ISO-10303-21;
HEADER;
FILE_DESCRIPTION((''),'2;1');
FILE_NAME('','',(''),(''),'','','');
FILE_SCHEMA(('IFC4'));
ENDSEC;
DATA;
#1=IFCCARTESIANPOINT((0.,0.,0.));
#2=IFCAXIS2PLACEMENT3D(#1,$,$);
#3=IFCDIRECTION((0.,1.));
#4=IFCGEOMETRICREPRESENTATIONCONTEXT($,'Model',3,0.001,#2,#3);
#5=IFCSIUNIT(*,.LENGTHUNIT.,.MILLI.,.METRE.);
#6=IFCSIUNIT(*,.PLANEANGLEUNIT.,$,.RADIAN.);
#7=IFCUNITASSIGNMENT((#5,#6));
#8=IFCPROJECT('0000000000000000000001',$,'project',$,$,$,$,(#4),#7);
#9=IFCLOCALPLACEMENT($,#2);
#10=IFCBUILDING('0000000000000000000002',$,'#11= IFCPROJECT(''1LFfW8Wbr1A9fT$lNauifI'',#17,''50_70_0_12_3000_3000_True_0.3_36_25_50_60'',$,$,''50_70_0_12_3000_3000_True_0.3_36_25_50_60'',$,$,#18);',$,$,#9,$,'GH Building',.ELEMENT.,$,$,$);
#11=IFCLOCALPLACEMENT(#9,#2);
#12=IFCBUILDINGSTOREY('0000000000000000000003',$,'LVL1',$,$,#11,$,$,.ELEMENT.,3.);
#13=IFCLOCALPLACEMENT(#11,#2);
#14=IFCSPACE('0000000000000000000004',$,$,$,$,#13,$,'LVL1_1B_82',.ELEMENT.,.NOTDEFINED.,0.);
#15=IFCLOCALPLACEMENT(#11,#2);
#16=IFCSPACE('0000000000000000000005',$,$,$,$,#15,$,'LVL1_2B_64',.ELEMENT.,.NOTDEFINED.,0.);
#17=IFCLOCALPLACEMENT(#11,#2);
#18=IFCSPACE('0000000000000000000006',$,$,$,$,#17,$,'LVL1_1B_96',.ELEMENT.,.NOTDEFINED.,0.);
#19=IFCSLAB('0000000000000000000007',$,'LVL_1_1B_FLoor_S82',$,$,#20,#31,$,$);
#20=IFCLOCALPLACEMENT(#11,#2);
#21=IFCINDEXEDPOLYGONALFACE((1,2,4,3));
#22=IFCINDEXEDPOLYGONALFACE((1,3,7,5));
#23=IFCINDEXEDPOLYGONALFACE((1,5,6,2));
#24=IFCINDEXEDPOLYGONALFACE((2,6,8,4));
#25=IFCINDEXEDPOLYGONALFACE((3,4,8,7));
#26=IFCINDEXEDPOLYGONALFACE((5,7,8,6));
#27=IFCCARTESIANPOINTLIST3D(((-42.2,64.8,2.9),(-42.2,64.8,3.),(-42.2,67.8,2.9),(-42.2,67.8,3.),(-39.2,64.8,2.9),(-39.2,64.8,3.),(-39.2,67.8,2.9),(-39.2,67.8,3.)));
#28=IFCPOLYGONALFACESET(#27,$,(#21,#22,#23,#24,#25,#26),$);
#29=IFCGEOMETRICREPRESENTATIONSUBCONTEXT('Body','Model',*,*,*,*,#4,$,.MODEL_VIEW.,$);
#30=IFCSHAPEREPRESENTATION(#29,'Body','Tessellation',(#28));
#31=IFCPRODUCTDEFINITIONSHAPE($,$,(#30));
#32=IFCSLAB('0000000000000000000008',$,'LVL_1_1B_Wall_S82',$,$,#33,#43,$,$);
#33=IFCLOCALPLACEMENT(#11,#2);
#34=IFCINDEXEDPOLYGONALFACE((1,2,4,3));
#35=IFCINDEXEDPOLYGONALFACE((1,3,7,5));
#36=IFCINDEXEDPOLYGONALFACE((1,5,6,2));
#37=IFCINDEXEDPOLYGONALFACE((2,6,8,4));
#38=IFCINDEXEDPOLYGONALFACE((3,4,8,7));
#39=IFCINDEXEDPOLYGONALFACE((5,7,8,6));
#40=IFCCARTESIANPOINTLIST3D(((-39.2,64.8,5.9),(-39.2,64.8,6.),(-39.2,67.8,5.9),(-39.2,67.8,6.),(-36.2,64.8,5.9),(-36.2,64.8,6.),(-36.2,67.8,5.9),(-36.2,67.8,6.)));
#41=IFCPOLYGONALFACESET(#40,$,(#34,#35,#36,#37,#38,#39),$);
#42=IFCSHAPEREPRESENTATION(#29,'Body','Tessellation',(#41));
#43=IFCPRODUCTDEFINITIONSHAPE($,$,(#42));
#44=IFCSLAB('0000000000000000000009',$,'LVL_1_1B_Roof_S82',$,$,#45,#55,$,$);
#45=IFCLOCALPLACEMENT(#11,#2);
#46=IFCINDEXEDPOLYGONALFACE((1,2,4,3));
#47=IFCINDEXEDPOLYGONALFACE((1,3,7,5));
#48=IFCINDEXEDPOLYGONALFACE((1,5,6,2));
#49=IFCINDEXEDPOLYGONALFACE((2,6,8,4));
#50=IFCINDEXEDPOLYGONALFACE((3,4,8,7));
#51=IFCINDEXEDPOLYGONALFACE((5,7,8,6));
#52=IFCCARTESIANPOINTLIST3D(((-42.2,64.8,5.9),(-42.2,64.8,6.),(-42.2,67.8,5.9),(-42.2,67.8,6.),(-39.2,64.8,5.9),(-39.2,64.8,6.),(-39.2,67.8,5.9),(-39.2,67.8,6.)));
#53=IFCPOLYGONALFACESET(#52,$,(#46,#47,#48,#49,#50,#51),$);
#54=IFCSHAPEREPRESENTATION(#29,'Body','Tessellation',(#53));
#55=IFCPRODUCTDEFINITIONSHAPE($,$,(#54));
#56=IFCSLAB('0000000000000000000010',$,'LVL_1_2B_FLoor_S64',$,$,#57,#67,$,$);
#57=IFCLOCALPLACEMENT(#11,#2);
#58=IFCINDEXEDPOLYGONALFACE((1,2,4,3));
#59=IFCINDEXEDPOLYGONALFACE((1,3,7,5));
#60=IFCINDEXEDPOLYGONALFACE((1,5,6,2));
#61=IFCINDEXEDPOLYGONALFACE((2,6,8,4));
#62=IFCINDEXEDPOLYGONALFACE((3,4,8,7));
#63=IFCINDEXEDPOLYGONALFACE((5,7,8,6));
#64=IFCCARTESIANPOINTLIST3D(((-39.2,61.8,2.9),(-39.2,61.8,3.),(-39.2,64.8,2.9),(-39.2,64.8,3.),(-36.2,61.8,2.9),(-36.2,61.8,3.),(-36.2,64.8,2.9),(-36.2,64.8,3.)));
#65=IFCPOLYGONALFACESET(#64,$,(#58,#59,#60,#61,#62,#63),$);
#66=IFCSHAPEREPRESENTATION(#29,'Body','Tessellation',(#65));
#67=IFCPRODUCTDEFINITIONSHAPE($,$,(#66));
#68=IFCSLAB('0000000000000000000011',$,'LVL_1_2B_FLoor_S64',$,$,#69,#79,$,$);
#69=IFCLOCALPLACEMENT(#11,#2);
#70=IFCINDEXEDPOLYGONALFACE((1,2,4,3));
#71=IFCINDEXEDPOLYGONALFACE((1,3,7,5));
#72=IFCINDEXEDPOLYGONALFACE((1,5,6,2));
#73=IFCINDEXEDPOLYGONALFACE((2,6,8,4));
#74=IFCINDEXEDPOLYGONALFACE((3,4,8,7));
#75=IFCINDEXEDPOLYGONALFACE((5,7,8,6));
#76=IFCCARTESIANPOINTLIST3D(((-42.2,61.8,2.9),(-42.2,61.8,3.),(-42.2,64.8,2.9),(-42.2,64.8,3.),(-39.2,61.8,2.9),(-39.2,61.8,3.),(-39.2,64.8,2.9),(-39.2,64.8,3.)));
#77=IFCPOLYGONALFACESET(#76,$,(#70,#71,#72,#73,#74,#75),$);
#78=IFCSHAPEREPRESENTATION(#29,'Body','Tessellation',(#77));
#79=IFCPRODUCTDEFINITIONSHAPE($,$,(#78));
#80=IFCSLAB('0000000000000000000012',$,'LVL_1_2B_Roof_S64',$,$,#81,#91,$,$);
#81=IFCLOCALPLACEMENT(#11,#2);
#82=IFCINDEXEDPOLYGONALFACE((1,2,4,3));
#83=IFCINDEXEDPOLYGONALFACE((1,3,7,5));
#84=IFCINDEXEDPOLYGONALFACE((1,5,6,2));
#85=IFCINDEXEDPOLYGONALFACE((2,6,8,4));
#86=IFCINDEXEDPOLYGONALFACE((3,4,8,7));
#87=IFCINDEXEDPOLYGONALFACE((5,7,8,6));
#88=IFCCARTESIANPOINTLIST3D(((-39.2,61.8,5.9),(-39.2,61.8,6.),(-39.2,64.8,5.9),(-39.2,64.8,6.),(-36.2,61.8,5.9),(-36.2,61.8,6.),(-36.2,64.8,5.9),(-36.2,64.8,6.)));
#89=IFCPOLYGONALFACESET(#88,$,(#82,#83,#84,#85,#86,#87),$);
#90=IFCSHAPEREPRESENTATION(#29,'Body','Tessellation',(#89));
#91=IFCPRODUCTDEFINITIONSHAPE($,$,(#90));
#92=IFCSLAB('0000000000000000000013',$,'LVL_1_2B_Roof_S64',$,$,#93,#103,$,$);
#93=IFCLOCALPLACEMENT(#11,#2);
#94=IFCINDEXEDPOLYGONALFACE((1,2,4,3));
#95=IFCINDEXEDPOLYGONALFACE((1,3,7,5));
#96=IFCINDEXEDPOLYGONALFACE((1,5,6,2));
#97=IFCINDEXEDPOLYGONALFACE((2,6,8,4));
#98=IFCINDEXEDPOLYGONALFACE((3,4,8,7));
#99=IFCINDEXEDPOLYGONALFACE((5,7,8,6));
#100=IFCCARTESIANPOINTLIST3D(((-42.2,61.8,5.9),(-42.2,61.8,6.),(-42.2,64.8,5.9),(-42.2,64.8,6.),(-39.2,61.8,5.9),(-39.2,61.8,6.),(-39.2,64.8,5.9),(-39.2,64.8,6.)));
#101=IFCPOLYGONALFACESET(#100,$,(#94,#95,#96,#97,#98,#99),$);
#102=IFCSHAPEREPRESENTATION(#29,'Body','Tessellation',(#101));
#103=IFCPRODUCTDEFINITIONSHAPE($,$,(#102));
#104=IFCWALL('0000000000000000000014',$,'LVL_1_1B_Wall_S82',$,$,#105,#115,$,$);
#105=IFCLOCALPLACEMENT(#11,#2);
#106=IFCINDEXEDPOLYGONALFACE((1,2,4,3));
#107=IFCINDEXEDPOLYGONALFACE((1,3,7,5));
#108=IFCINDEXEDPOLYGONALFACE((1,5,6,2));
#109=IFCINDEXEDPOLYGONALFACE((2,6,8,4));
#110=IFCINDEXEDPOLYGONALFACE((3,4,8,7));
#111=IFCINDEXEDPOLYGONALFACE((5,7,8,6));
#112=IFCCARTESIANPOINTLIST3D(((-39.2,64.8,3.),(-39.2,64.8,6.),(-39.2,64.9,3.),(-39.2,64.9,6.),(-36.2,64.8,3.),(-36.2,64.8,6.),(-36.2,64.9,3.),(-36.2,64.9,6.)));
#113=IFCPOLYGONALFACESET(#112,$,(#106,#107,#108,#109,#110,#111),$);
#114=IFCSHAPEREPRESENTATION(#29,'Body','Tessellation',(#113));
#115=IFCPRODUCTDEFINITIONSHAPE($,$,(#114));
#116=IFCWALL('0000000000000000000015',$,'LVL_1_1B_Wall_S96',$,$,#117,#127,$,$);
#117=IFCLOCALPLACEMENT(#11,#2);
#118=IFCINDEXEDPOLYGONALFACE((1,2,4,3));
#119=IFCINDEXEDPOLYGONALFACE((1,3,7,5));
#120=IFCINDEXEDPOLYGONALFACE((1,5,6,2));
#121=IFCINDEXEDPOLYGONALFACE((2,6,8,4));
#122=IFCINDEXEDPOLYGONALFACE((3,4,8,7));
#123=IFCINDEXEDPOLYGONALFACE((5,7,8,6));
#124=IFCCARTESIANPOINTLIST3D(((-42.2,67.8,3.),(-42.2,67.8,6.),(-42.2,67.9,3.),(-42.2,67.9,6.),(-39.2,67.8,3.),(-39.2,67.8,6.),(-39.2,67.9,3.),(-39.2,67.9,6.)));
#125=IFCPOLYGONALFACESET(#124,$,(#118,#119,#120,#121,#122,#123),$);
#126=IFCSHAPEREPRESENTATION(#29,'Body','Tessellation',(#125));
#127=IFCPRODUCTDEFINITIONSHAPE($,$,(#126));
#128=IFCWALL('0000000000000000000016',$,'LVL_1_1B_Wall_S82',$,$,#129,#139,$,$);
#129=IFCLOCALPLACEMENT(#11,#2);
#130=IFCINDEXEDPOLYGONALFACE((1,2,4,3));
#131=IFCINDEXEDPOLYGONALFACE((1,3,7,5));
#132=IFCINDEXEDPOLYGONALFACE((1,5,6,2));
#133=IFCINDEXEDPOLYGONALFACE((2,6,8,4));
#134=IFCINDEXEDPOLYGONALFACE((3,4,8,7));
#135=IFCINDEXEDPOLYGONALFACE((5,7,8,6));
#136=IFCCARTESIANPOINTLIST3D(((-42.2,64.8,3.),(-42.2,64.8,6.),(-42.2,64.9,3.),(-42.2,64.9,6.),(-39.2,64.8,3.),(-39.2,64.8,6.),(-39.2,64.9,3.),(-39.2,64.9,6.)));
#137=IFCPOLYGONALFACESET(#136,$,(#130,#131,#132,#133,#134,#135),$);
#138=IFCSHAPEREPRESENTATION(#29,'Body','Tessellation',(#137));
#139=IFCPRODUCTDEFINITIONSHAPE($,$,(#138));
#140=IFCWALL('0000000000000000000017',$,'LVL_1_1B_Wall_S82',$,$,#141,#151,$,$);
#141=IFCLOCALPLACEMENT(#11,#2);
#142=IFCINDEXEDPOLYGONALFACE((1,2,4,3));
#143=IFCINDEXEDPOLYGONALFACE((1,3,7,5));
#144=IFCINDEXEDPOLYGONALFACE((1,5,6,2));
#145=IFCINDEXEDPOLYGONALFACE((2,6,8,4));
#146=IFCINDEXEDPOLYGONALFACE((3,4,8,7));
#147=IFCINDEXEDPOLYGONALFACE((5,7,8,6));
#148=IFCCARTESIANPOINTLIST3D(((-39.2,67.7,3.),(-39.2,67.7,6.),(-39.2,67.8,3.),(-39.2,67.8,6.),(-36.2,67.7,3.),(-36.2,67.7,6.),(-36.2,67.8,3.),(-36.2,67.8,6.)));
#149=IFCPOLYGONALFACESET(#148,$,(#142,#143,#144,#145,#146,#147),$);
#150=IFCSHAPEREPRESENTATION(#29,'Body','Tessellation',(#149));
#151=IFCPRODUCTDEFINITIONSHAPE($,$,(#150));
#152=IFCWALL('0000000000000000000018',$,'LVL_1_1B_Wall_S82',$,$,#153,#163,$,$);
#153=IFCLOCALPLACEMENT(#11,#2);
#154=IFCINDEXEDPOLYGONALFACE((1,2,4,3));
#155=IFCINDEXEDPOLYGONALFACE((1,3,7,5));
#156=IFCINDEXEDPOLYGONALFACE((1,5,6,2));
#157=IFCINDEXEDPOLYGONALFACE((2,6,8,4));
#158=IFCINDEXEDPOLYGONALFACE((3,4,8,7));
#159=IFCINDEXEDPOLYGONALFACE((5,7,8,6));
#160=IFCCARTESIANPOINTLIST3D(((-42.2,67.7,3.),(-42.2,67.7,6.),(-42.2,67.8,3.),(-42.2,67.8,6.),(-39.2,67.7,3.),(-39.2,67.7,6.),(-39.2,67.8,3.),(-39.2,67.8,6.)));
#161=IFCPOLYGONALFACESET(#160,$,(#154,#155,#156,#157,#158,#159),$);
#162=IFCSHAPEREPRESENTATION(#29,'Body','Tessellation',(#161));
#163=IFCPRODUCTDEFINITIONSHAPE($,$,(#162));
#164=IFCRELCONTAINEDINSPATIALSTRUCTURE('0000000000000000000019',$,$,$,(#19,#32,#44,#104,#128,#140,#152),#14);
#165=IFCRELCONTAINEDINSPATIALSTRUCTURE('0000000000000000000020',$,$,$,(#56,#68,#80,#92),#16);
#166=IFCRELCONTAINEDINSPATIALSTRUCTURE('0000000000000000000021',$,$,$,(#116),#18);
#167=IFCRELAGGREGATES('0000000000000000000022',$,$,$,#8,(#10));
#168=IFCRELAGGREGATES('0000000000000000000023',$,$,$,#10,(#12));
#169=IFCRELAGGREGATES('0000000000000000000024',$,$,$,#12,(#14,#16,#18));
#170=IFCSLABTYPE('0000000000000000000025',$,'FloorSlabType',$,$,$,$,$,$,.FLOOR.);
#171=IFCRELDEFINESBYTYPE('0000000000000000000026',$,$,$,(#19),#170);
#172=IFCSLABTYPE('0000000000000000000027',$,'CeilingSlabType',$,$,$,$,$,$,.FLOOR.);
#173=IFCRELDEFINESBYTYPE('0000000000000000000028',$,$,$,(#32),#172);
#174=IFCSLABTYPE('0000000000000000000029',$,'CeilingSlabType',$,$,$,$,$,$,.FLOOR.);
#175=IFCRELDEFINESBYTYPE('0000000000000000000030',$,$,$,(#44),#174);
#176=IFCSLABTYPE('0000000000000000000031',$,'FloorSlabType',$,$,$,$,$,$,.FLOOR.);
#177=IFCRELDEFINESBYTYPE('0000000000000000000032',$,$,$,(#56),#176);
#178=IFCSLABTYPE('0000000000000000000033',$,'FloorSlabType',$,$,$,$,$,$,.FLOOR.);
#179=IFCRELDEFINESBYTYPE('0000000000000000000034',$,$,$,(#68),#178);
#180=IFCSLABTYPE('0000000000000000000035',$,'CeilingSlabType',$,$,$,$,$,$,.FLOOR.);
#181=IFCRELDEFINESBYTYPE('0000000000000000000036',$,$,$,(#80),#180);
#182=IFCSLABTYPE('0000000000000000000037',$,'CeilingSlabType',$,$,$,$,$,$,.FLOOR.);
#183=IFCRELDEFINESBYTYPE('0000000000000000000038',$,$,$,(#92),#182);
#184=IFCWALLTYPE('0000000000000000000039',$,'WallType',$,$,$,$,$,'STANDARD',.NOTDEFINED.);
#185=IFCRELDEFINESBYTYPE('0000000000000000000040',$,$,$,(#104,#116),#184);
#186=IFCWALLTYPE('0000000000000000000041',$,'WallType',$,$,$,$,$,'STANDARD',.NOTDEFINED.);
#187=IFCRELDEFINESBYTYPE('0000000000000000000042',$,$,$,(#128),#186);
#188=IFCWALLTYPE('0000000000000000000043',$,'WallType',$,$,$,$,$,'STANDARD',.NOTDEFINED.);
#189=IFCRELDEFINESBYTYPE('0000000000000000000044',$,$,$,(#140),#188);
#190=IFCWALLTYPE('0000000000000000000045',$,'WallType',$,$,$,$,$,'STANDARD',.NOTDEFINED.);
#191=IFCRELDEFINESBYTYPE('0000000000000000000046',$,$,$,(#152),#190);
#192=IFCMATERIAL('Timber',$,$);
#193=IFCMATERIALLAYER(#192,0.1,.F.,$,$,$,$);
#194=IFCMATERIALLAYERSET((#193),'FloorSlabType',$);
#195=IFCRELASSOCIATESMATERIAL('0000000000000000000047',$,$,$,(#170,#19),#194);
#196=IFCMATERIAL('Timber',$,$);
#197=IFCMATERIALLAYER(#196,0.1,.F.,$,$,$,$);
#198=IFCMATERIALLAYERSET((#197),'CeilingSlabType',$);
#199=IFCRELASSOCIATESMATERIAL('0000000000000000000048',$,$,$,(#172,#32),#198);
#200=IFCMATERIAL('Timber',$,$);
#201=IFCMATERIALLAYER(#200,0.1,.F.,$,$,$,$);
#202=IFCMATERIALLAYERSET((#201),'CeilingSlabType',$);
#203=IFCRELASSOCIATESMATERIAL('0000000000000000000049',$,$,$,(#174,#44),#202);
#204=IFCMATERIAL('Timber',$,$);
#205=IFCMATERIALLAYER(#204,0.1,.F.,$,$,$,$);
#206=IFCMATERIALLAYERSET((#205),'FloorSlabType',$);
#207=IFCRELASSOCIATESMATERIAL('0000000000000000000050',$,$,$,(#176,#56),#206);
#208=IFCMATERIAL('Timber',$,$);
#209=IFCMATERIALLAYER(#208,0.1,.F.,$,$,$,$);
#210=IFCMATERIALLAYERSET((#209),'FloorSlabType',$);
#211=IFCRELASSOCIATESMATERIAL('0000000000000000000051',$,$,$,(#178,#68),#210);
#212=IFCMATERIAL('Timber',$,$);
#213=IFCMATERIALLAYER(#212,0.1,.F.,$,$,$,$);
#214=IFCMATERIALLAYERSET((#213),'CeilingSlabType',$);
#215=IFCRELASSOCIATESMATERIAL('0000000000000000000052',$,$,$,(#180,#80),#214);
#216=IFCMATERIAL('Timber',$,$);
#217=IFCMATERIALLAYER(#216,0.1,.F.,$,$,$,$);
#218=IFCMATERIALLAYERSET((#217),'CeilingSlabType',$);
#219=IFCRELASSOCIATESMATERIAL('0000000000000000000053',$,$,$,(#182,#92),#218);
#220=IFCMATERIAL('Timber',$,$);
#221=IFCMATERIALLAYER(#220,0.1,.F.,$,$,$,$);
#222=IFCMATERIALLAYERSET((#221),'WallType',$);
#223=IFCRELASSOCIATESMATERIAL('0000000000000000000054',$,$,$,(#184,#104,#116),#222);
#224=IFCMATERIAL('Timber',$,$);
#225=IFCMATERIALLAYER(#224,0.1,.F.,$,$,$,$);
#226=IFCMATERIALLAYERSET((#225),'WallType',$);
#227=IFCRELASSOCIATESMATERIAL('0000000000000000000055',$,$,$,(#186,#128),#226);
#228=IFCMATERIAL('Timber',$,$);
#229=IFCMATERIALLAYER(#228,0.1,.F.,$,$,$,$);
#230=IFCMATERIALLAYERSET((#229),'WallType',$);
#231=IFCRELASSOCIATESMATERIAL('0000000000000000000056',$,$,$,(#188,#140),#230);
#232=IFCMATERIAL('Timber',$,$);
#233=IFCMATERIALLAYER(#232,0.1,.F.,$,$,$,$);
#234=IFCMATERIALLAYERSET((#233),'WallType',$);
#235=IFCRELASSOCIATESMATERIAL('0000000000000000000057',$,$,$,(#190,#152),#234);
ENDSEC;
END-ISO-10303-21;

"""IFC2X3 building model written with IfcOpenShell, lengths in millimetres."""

from ifc_helpers import new_model, si_unit, direction, frame, frame_2d, origin, place, context, subcontext, project, spatial, rectangle, extrude, material, layer, layer_set, layer_usage, type_object, element, save


model = new_model("IFC2X3")

# Units and contexts
model_context = context("Model", 3, precision=0.001, world=origin(), true_north=direction((0.0, 1.0)))
body_context = subcontext(model_context, "Body", "Model", "MODEL_VIEW")
ifc_project = project(units=[si_unit("LENGTHUNIT", "METRE", prefix="MILLI"), si_unit("PLANEANGLEUNIT", "RADIAN")], contexts=[model_context])

# Building, storey
building_placement = place(None, origin())
building = spatial("IfcBuilding", under=ifc_project, at=building_placement, Name="#11= IFCPROJECT('1LFfW8Wbr1A9fT$lNauifI',#17,'50_70_0_12_3000_3000_True_0.3_36_25_50_60',$,$,'50_70_0_12_3000_3000_True_0.3_36_25_50_60',$,$,#18);", LongName="GH Building", CompositionType="ELEMENT")
storey_placement = place(building_placement, origin())
storey = spatial("IfcBuildingStorey", under=building, at=storey_placement, Name="LVL1", CompositionType="ELEMENT", Elevation=3.0)

# Shared definitions
space_1_placement = place(storey_placement, origin())
space_1 = spatial("IfcSpace", under=storey, at=space_1_placement, LongName="LVL1_1B_82", CompositionType="ELEMENT", InteriorOrExteriorSpace="NOTDEFINED", ElevationWithFlooring=0.0)

# Slabs
ifc_material_1 = material(Name="Timber")
ifc_layer_1 = layer(ifc_material_1, 0.1, ventilated=False)
ifc_layer_set_1 = layer_set([ifc_layer_1], Name="FloorSlabType")
ifc_layer_usage_1 = layer_usage(ifc_layer_set_1, "AXIS3", "NEGATIVE", -0.1)
slab_type_1 = type_object("IfcSlabType", Name="FloorSlabType", PredefinedType="FLOOR", material=ifc_layer_set_1)
slab_1_placement = place(space_1_placement, frame((-39.2, 67.8, 2.9), z_axis=(0.0, 0.0, 1.0), x_axis=(-1.0, 0.0, 0.0)))
element("IfcSlab", 1, at=slab_1_placement, inside=space_1, type_object=slab_type_1, material=ifc_layer_usage_1, Name="LVL_1_1B_FLoor_S82", context=body_context, shape_type="SweptSolid", body=[
    extrude(rectangle(XDim=3.0, YDim=3.0, at=frame_2d((1.5, 1.5))), origin(), (0.0, 0.0, 1.0), 0.1),
])
ifc_material_2 = material(Name="Timber")
ifc_layer_2 = layer(ifc_material_2, 0.1, ventilated=False)
ifc_layer_set_2 = layer_set([ifc_layer_2], Name="CeilingSlabType")
ifc_layer_usage_2 = layer_usage(ifc_layer_set_2, "AXIS3", "NEGATIVE", -0.1)
slab_type_2 = type_object("IfcSlabType", Name="CeilingSlabType", PredefinedType="FLOOR", material=ifc_layer_set_2)
slab_2_placement = place(space_1_placement, frame((-36.2, 67.8, 5.9), z_axis=(0.0, 0.0, 1.0), x_axis=(-1.0, 0.0, 0.0)))
element("IfcSlab", 2, at=slab_2_placement, inside=space_1, type_object=slab_type_2, material=ifc_layer_usage_2, Name="LVL_1_1B_Wall_S82", context=body_context, shape_type="SweptSolid", body=[
    extrude(rectangle(XDim=3.0, YDim=3.0, at=frame_2d((1.5, 1.5))), origin(), (0.0, 0.0, 1.0), 0.1),
])
ifc_material_3 = material(Name="Timber")
ifc_layer_3 = layer(ifc_material_3, 0.1, ventilated=False)
ifc_layer_set_3 = layer_set([ifc_layer_3], Name="CeilingSlabType")
ifc_layer_usage_3 = layer_usage(ifc_layer_set_3, "AXIS3", "NEGATIVE", -0.1)
slab_type_3 = type_object("IfcSlabType", Name="CeilingSlabType", PredefinedType="FLOOR", material=ifc_layer_set_3)
slab_3_placement = place(space_1_placement, frame((-39.2, 67.8, 5.9), z_axis=(0.0, 0.0, 1.0), x_axis=(-1.0, 0.0, 0.0)))
element("IfcSlab", 3, at=slab_3_placement, inside=space_1, type_object=slab_type_3, material=ifc_layer_usage_3, Name="LVL_1_1B_Roof_S82", context=body_context, shape_type="SweptSolid", body=[
    extrude(rectangle(XDim=3.0, YDim=3.0, at=frame_2d((1.5, 1.5))), origin(), (0.0, 0.0, 1.0), 0.1),
])

# Shared definitions
space_2_placement = place(storey_placement, origin())
space_2 = spatial("IfcSpace", under=storey, at=space_2_placement, LongName="LVL1_2B_64", CompositionType="ELEMENT", InteriorOrExteriorSpace="NOTDEFINED", ElevationWithFlooring=0.0)

# Slabs
ifc_material_4 = material(Name="Timber")
ifc_layer_4 = layer(ifc_material_4, 0.1, ventilated=False)
ifc_layer_set_4 = layer_set([ifc_layer_4], Name="FloorSlabType")
ifc_layer_usage_4 = layer_usage(ifc_layer_set_4, "AXIS3", "NEGATIVE", -0.1)
slab_type_4 = type_object("IfcSlabType", Name="FloorSlabType", PredefinedType="FLOOR", material=ifc_layer_set_4)
slab_4_placement = place(space_2_placement, frame((-39.2, 64.8, 2.9), z_axis=(0.0, 0.0, 1.0), x_axis=(0.0, -1.0, 0.0)))
element("IfcSlab", 4, at=slab_4_placement, inside=space_2, type_object=slab_type_4, material=ifc_layer_usage_4, Name="LVL_1_2B_FLoor_S64", context=body_context, shape_type="SweptSolid", body=[
    extrude(rectangle(XDim=3.0, YDim=3.0, at=frame_2d((1.5, 1.5))), origin(), (0.0, 0.0, 1.0), 0.1),
])
ifc_material_5 = material(Name="Timber")
ifc_layer_5 = layer(ifc_material_5, 0.1, ventilated=False)
ifc_layer_set_5 = layer_set([ifc_layer_5], Name="FloorSlabType")
ifc_layer_usage_5 = layer_usage(ifc_layer_set_5, "AXIS3", "NEGATIVE", -0.1)
slab_type_5 = type_object("IfcSlabType", Name="FloorSlabType", PredefinedType="FLOOR", material=ifc_layer_set_5)
slab_5_placement = place(space_2_placement, frame((-42.2, 64.8, 2.9), z_axis=(0.0, 0.0, 1.0), x_axis=(0.0, -1.0, 0.0)))
element("IfcSlab", 5, at=slab_5_placement, inside=space_2, type_object=slab_type_5, material=ifc_layer_usage_5, Name="LVL_1_2B_FLoor_S64", context=body_context, shape_type="SweptSolid", body=[
    extrude(rectangle(XDim=3.0, YDim=3.0, at=frame_2d((1.5, 1.5))), origin(), (0.0, 0.0, 1.0), 0.1),
])
ifc_material_6 = material(Name="Timber")
ifc_layer_6 = layer(ifc_material_6, 0.1, ventilated=False)
ifc_layer_set_6 = layer_set([ifc_layer_6], Name="CeilingSlabType")
ifc_layer_usage_6 = layer_usage(ifc_layer_set_6, "AXIS3", "NEGATIVE", -0.1)
slab_type_6 = type_object("IfcSlabType", Name="CeilingSlabType", PredefinedType="FLOOR", material=ifc_layer_set_6)
slab_6_placement = place(space_2_placement, frame((-39.2, 64.8, 5.9), z_axis=(0.0, 0.0, 1.0), x_axis=(0.0, -1.0, 0.0)))
element("IfcSlab", 6, at=slab_6_placement, inside=space_2, type_object=slab_type_6, material=ifc_layer_usage_6, Name="LVL_1_2B_Roof_S64", context=body_context, shape_type="SweptSolid", body=[
    extrude(rectangle(XDim=3.0, YDim=3.0, at=frame_2d((1.5, 1.5))), origin(), (0.0, 0.0, 1.0), 0.1),
])
ifc_material_7 = material(Name="Timber")
ifc_layer_7 = layer(ifc_material_7, 0.1, ventilated=False)
ifc_layer_set_7 = layer_set([ifc_layer_7], Name="CeilingSlabType")
ifc_layer_usage_7 = layer_usage(ifc_layer_set_7, "AXIS3", "NEGATIVE", -0.1)
slab_type_7 = type_object("IfcSlabType", Name="CeilingSlabType", PredefinedType="FLOOR", material=ifc_layer_set_7)
slab_7_placement = place(space_2_placement, frame((-42.2, 64.8, 5.9), z_axis=(0.0, 0.0, 1.0), x_axis=(0.0, -1.0, 0.0)))
element("IfcSlab", 7, at=slab_7_placement, inside=space_2, type_object=slab_type_7, material=ifc_layer_usage_7, Name="LVL_1_2B_Roof_S64", context=body_context, shape_type="SweptSolid", body=[
    extrude(rectangle(XDim=3.0, YDim=3.0, at=frame_2d((1.5, 1.5))), origin(), (0.0, 0.0, 1.0), 0.1),
])

# Shared definitions
space_3_placement = place(storey_placement, origin())
space_3 = spatial("IfcSpace", under=storey, at=space_3_placement, LongName="LVL1_1B_96", CompositionType="ELEMENT", InteriorOrExteriorSpace="NOTDEFINED", ElevationWithFlooring=0.0)

# Walls
ifc_material_8 = material(Name="Timber")
ifc_layer_8 = layer(ifc_material_8, 0.1, ventilated=False)
ifc_layer_set_8 = layer_set([ifc_layer_8], Name="WallType")
ifc_layer_usage_8 = layer_usage(ifc_layer_set_8, "AXIS2", "NEGATIVE", 0.0)
wall_type_1 = type_object("IfcWallType", Name="WallType", ElementType="STANDARD", PredefinedType="NOTDEFINED", material=ifc_layer_set_8)
wall_1_placement = place(space_1_placement, frame((-36.2, 64.8, 3.0), z_axis=(0.0, 0.0, 1.0), x_axis=(-1.0, 0.0, 0.0)))
element("IfcWall", 8, at=wall_1_placement, inside=space_1, type_object=wall_type_1, material=ifc_layer_usage_8, Name="LVL_1_1B_Wall_S82", context=body_context, shape_type="SweptSolid", body=[
    extrude(rectangle(XDim=3.0, YDim=0.1, at=frame_2d((1.5, -0.1))), origin(), (0.0, 0.0, 1.0), 3.0),
])
ifc_layer_usage_9 = layer_usage(ifc_layer_set_8, "AXIS2", "NEGATIVE", 0.0)
wall_2_placement = place(space_3_placement, frame((-39.2, 67.8, 3.0), z_axis=(0.0, 0.0, 1.0), x_axis=(-1.0, 0.0, 0.0)))
element("IfcWall", 9, at=wall_2_placement, inside=space_3, type_object=wall_type_1, material=ifc_layer_usage_9, Name="LVL_1_1B_Wall_S96", context=body_context, shape_type="SweptSolid", body=[
    extrude(rectangle(XDim=3.0, YDim=0.1, at=frame_2d((1.5, -0.1))), origin(), (0.0, 0.0, 1.0), 3.0),
])
ifc_material_9 = material(Name="Timber")
ifc_layer_9 = layer(ifc_material_9, 0.1, ventilated=False)
ifc_layer_set_9 = layer_set([ifc_layer_9], Name="WallType")
ifc_layer_usage_10 = layer_usage(ifc_layer_set_9, "AXIS2", "NEGATIVE", 0.0)
wall_type_2 = type_object("IfcWallType", Name="WallType", ElementType="STANDARD", PredefinedType="NOTDEFINED", material=ifc_layer_set_9)
wall_3_placement = place(space_1_placement, frame((-39.2, 64.8, 3.0), z_axis=(0.0, 0.0, 1.0), x_axis=(-1.0, 0.0, 0.0)))
element("IfcWall", 10, at=wall_3_placement, inside=space_1, type_object=wall_type_2, material=ifc_layer_usage_10, Name="LVL_1_1B_Wall_S82", context=body_context, shape_type="SweptSolid", body=[
    extrude(rectangle(XDim=3.0, YDim=0.1, at=frame_2d((1.5, -0.1))), origin(), (0.0, 0.0, 1.0), 3.0),
])
ifc_material_10 = material(Name="Timber")
ifc_layer_10 = layer(ifc_material_10, 0.1, ventilated=False)
ifc_layer_set_10 = layer_set([ifc_layer_10], Name="WallType")
ifc_layer_usage_11 = layer_usage(ifc_layer_set_10, "AXIS2", "NEGATIVE", 0.0)
wall_type_3 = type_object("IfcWallType", Name="WallType", ElementType="STANDARD", PredefinedType="NOTDEFINED", material=ifc_layer_set_10)
wall_4_placement = place(space_1_placement, frame((-39.2, 67.8, 3.0)))
element("IfcWall", 11, at=wall_4_placement, inside=space_1, type_object=wall_type_3, material=ifc_layer_usage_11, Name="LVL_1_1B_Wall_S82", context=body_context, shape_type="SweptSolid", body=[
    extrude(rectangle(XDim=3.0, YDim=0.1, at=frame_2d((1.5, -0.1))), origin(), (0.0, 0.0, 1.0), 3.0),
])
ifc_material_11 = material(Name="Timber")
ifc_layer_11 = layer(ifc_material_11, 0.1, ventilated=False)
ifc_layer_set_11 = layer_set([ifc_layer_11], Name="WallType")
ifc_layer_usage_12 = layer_usage(ifc_layer_set_11, "AXIS2", "NEGATIVE", 0.0)
wall_type_4 = type_object("IfcWallType", Name="WallType", ElementType="STANDARD", PredefinedType="NOTDEFINED", material=ifc_layer_set_11)
wall_5_placement = place(space_1_placement, frame((-42.2, 67.8, 3.0)))
element("IfcWall", 12, at=wall_5_placement, inside=space_1, type_object=wall_type_4, material=ifc_layer_usage_12, Name="LVL_1_1B_Wall_S82", context=body_context, shape_type="SweptSolid", body=[
    extrude(rectangle(XDim=3.0, YDim=0.1, at=frame_2d((1.5, -0.1))), origin(), (0.0, 0.0, 1.0), 3.0),
])

save(model, "model.ifc")
